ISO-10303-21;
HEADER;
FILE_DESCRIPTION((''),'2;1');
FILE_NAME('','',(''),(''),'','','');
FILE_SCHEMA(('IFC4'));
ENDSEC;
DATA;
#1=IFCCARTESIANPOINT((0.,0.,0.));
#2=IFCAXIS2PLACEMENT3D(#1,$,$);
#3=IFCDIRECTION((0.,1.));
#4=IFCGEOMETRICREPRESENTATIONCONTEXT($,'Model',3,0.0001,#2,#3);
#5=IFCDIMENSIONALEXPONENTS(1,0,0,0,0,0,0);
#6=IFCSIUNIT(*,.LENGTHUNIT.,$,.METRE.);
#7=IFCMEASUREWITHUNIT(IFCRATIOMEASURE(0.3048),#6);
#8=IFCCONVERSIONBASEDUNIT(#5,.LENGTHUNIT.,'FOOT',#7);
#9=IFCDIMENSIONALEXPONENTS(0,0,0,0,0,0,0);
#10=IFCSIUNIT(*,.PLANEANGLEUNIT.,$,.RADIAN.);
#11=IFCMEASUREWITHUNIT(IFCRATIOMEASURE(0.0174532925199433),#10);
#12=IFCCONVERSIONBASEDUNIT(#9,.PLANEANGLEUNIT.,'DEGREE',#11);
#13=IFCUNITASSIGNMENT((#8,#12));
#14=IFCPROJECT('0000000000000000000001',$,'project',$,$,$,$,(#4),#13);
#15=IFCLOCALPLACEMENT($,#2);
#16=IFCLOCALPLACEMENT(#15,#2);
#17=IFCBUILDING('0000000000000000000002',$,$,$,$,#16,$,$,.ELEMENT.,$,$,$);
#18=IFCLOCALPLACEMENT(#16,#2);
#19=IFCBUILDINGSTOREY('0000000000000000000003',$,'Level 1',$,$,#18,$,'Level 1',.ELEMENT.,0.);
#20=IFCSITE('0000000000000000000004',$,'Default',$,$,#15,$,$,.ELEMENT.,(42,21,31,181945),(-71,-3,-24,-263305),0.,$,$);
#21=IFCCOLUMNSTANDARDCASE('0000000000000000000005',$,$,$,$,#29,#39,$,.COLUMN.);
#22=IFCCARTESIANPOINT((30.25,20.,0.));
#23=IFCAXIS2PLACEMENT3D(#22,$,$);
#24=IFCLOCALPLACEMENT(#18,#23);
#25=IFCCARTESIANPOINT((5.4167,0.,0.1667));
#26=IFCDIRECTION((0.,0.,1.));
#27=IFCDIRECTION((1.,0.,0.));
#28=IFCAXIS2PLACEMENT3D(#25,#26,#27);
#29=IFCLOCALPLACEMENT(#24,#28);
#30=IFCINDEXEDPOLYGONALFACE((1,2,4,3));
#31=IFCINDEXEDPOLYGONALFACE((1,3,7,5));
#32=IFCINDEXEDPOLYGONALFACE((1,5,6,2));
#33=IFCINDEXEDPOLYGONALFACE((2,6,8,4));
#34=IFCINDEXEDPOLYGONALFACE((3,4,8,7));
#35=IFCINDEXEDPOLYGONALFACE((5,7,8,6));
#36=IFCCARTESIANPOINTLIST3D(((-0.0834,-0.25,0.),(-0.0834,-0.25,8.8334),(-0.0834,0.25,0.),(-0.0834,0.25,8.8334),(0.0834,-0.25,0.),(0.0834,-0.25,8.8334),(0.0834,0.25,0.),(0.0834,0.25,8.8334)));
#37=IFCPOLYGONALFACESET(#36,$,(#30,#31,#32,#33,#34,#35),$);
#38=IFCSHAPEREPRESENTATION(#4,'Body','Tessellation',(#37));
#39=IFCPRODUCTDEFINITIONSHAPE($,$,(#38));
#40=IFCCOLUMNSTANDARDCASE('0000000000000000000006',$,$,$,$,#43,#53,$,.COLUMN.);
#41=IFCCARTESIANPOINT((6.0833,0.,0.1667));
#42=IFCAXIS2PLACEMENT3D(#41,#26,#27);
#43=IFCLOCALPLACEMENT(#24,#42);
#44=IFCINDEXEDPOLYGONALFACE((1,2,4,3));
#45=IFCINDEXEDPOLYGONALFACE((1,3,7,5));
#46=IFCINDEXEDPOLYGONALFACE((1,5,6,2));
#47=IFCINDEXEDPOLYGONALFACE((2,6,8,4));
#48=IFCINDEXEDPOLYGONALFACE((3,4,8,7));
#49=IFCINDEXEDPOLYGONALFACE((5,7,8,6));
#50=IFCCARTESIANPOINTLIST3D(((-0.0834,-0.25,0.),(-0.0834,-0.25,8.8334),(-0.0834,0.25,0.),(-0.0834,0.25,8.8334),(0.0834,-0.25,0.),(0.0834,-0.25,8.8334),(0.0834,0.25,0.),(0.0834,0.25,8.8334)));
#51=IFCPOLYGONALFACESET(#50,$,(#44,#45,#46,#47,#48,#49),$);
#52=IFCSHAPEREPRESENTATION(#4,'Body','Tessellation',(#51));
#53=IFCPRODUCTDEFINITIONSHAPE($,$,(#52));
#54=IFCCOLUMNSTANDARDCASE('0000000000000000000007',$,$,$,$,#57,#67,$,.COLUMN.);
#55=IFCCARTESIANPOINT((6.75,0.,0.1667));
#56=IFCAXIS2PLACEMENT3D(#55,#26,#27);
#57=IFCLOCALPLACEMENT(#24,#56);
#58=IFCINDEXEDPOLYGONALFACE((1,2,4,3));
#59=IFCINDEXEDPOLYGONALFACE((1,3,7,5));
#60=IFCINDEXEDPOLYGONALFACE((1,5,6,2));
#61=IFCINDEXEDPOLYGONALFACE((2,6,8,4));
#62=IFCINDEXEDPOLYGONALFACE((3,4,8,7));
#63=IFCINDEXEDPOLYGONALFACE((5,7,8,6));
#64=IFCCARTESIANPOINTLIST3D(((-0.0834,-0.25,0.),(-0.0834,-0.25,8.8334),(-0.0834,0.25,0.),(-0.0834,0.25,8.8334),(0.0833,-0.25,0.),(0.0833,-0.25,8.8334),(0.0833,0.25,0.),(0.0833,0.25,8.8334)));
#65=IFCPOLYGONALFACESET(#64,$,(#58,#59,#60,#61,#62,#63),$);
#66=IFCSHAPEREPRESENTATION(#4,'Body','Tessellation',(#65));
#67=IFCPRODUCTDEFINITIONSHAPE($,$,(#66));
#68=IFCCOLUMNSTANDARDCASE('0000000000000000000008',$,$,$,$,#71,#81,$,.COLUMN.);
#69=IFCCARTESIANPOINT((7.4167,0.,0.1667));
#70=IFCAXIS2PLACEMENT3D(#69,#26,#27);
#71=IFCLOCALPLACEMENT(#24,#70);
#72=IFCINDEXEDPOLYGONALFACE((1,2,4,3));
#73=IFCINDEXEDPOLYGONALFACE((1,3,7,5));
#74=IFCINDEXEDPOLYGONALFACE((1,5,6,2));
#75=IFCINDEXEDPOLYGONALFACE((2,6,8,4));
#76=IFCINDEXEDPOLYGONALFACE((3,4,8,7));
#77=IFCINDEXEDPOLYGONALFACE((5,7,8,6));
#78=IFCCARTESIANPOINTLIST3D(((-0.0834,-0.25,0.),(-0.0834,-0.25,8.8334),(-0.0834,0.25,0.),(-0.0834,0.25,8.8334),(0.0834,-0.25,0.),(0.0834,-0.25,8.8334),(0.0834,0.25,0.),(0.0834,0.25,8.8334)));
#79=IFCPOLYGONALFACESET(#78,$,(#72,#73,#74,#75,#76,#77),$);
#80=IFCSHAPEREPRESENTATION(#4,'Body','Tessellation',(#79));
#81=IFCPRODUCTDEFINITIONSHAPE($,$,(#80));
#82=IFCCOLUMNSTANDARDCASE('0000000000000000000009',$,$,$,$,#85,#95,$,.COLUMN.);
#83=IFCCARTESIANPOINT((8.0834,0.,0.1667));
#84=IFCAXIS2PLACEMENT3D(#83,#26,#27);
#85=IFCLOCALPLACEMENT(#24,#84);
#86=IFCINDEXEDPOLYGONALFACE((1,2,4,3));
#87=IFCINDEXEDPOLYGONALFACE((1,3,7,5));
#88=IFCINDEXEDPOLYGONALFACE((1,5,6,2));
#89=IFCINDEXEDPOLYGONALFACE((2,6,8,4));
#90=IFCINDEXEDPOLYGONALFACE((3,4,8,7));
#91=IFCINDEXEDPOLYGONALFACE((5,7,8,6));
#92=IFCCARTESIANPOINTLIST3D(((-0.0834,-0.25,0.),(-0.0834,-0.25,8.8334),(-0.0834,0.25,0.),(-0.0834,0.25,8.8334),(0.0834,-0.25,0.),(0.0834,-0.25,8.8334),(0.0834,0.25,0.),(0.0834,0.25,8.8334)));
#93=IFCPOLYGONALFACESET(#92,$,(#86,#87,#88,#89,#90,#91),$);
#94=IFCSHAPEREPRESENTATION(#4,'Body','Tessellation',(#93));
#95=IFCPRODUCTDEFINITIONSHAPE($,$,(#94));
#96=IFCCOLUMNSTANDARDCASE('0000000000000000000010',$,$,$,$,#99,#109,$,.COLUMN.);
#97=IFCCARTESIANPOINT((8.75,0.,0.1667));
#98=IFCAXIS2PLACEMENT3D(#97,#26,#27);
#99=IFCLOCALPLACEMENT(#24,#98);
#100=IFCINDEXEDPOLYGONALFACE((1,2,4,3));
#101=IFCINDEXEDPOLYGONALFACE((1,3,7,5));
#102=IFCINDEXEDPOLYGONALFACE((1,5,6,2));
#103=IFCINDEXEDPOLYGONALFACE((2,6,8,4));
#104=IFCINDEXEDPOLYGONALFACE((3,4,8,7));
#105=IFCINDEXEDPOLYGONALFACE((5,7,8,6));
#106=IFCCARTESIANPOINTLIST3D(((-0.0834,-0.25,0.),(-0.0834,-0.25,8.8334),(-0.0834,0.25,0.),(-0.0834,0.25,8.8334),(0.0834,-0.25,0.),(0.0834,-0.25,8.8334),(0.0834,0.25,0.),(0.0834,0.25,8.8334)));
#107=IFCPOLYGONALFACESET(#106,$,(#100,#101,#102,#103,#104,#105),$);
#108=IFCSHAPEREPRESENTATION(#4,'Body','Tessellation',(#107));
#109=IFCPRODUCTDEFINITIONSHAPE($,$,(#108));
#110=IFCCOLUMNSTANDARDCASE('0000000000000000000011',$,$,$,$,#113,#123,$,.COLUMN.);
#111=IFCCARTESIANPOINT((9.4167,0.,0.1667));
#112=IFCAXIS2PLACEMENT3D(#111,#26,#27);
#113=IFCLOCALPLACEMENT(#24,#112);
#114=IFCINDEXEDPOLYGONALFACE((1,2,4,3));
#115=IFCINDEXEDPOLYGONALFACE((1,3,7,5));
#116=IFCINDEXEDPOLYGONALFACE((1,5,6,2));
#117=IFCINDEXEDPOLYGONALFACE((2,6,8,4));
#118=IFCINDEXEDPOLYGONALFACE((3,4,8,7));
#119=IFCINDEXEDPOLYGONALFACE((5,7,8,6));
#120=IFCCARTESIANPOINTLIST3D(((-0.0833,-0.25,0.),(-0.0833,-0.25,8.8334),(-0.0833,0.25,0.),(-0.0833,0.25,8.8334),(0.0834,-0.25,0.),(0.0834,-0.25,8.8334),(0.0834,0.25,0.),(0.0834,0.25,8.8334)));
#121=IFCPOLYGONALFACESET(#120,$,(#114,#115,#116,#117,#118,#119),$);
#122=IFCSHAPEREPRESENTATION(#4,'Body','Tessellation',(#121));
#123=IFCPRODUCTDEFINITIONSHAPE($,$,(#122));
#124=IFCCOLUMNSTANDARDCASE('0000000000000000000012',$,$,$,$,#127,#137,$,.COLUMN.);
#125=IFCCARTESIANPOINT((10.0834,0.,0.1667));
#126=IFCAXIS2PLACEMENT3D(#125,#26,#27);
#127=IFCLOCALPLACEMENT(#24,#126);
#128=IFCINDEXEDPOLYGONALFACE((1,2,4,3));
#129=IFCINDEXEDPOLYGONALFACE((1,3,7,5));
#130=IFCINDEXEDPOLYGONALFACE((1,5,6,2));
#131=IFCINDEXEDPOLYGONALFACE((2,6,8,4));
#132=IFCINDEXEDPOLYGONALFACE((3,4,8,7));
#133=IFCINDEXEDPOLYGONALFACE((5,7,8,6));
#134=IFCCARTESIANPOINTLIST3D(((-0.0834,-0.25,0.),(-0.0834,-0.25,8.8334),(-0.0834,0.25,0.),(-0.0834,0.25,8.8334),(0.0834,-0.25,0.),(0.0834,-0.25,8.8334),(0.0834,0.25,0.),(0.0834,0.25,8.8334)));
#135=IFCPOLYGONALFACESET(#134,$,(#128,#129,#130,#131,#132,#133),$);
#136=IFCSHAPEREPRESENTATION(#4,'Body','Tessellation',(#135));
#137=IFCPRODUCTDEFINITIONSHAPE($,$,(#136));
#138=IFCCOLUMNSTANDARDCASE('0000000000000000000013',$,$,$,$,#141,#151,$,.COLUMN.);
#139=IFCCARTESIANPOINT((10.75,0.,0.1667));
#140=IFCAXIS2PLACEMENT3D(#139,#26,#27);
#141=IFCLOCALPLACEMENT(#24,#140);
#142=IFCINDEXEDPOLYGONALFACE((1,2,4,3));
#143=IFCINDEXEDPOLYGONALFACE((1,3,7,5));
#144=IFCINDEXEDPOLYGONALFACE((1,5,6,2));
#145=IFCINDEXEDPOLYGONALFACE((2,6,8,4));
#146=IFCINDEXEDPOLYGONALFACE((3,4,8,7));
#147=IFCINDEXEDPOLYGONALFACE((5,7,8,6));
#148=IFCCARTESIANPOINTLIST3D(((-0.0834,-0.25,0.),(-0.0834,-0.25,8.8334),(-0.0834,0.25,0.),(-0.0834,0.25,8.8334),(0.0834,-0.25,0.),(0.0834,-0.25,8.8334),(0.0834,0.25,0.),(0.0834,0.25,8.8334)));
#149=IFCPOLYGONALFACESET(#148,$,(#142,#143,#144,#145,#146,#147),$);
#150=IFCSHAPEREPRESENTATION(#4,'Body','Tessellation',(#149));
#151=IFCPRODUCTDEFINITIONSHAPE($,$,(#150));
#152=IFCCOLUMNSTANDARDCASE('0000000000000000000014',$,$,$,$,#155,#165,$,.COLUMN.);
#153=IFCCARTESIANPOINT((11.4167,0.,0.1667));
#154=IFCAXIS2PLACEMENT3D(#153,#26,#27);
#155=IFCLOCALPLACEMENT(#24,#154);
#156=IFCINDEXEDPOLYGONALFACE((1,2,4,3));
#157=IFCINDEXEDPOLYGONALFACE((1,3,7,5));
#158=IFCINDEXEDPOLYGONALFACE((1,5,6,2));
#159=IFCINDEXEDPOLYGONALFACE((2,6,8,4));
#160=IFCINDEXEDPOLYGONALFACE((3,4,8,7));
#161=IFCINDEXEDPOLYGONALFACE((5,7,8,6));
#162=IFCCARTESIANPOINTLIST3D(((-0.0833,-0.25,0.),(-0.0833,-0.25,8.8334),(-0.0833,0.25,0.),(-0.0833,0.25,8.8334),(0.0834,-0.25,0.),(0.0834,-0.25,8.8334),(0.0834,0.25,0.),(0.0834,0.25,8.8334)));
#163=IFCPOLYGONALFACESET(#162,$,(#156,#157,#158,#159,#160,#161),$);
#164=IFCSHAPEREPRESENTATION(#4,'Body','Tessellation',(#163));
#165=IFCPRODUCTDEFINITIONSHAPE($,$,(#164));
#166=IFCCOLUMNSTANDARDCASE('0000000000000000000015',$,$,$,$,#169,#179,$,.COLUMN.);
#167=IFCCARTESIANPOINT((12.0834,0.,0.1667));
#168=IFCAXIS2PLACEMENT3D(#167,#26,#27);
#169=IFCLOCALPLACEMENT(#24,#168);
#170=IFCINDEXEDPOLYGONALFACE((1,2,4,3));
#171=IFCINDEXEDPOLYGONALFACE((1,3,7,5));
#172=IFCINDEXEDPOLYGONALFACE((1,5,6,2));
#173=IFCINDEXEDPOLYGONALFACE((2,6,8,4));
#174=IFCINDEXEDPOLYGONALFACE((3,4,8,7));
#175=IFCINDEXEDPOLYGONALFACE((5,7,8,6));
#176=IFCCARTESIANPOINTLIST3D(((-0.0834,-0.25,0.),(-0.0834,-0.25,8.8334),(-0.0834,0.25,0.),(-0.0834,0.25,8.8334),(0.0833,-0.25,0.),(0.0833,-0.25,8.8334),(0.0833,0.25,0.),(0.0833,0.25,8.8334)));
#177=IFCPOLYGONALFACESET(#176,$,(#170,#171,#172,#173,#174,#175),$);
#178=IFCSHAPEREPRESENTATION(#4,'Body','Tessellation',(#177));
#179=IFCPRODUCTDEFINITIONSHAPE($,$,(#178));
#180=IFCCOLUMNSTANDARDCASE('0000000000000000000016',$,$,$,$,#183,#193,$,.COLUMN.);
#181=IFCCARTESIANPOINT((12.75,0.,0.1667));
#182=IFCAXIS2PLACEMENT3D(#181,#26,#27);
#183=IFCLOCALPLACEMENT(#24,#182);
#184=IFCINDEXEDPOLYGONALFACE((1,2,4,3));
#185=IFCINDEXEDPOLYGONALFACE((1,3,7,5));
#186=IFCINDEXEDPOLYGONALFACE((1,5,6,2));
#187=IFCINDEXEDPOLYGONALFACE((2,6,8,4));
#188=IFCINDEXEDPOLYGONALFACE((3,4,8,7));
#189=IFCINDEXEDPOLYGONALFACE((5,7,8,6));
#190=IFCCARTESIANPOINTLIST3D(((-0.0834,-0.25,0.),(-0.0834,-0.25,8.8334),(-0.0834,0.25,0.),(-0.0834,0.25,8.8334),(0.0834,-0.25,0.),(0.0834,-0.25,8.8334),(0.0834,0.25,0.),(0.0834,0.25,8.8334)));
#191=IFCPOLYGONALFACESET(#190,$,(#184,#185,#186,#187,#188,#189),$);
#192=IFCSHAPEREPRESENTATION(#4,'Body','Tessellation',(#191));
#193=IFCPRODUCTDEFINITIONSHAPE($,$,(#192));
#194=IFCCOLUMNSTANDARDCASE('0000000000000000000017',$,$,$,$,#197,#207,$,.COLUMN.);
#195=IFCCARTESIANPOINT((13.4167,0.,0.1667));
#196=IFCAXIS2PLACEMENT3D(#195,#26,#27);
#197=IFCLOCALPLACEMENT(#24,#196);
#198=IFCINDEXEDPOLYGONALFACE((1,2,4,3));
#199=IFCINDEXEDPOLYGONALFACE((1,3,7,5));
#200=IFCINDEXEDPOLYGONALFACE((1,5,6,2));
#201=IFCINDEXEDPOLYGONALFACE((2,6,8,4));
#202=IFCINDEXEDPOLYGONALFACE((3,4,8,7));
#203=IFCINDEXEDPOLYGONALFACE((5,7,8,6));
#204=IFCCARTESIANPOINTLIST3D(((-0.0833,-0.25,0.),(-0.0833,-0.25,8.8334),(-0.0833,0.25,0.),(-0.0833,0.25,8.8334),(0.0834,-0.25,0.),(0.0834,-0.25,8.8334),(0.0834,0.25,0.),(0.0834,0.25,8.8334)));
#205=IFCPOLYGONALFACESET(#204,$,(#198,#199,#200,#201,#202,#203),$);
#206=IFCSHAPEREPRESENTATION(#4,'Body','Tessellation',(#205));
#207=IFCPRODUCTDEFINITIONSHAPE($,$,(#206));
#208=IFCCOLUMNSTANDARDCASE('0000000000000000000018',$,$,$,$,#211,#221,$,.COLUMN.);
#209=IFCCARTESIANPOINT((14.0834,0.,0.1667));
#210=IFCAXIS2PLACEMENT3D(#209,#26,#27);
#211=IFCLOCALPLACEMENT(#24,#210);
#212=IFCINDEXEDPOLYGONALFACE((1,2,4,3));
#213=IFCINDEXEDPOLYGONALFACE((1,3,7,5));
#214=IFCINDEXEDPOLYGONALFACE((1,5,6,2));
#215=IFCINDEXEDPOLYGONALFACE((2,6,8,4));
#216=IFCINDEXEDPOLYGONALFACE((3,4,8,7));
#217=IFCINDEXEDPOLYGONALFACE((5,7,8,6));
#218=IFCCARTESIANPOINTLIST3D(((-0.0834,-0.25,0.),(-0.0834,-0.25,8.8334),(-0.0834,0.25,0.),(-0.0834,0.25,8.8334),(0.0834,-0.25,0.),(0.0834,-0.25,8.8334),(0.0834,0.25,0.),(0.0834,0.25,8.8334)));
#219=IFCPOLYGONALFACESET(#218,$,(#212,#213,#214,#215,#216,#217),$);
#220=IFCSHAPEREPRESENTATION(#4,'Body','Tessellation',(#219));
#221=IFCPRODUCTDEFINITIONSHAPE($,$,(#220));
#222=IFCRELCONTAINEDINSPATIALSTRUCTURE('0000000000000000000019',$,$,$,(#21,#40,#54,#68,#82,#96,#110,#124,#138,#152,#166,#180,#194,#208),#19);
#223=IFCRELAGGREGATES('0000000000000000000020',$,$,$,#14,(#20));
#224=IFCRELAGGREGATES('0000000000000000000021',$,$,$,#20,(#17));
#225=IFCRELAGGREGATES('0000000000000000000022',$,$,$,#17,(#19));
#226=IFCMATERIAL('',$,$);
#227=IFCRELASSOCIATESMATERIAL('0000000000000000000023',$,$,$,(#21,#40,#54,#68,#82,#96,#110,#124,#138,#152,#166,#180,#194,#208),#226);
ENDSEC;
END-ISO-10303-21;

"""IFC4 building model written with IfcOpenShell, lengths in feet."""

from ifc_helpers import new_model, entity, si_unit, converted_unit, direction, frame, origin, place, context, project, spatial, rectangle, extrude, material, element, save


model = new_model("IFC4")

# Units and contexts
model_context = context("Model", 3, precision=0.0001, world=origin(), true_north=direction((0.0, 1.0)))
ifc_project = project(units=[converted_unit("LENGTHUNIT", "FOOT", entity("IfcRatioMeasure", 0.3048), si_unit("LENGTHUNIT", "METRE"), dimensions=[1, 0, 0, 0, 0, 0, 0]), converted_unit("PLANEANGLEUNIT", "DEGREE", entity("IfcRatioMeasure", 0.0174532925199433), si_unit("PLANEANGLEUNIT", "RADIAN"), dimensions=[0, 0, 0, 0, 0, 0, 0])], contexts=[model_context])

# Site, building, storey
site_placement = place(None, origin())
site = spatial("IfcSite", under=ifc_project, at=site_placement, Name="Default", CompositionType="ELEMENT", RefLatitude=(42, 21, 31, 181945), RefLongitude=(-71, -3, -24, -263305), RefElevation=0.0)
building_placement = place(site_placement, origin())
building = spatial("IfcBuilding", under=site, at=building_placement, CompositionType="ELEMENT")
storey_placement = place(building_placement, origin())
storey = spatial("IfcBuildingStorey", under=building, at=storey_placement, Name="Level 1", LongName="Level 1", CompositionType="ELEMENT", Elevation=0.0)

# Columns
ifc_material_1 = material(Name="")
placement = place(storey_placement, frame((30.25, 20.0, 0.0)))
for number, where, z_axis, x_axis in (
    (1, (5.4167, 0.0, 0.1667), (0.0, 0.0, 1.0), (1.0, 0.0, 0.0)),
    (2, (6.0833, 0.0, 0.1667), (0.0, 0.0, 1.0), (1.0, 0.0, 0.0)),
    (3, (6.75, 0.0, 0.1667), (0.0, 0.0, 1.0), (1.0, 0.0, 0.0)),
    (4, (7.4167, 0.0, 0.1667), (0.0, 0.0, 1.0), (1.0, 0.0, 0.0)),
    (5, (8.0834, 0.0, 0.1667), (0.0, 0.0, 1.0), (1.0, 0.0, 0.0)),
    (6, (8.75, 0.0, 0.1667), (0.0, 0.0, 1.0), (1.0, 0.0, 0.0)),
    (7, (9.4167, 0.0, 0.1667), (0.0, 0.0, 1.0), (1.0, 0.0, 0.0)),
    (8, (10.0834, 0.0, 0.1667), (0.0, 0.0, 1.0), (1.0, 0.0, 0.0)),
    (9, (10.75, 0.0, 0.1667), (0.0, 0.0, 1.0), (1.0, 0.0, 0.0)),
    (10, (11.4167, 0.0, 0.1667), (0.0, 0.0, 1.0), (1.0, 0.0, 0.0)),
    (11, (12.0834, 0.0, 0.1667), (0.0, 0.0, 1.0), (1.0, 0.0, 0.0)),
    (12, (12.75, 0.0, 0.1667), (0.0, 0.0, 1.0), (1.0, 0.0, 0.0)),
    (13, (13.4167, 0.0, 0.1667), (0.0, 0.0, 1.0), (1.0, 0.0, 0.0)),
    (14, (14.0834, 0.0, 0.1667), (0.0, 0.0, 1.0), (1.0, 0.0, 0.0)),
):
    element("IfcColumnStandardCase", number, at=place(placement, frame(where, z_axis=z_axis, x_axis=x_axis)), inside=storey, material=ifc_material_1, PredefinedType="COLUMN", context=model_context, shape_type="SweptSolid", body=[
        extrude(rectangle(XDim=0.1667, YDim=0.5), origin(), (0.0, 0.0, 1.0), 8.8334),
    ])

save(model, "model.ifc")
